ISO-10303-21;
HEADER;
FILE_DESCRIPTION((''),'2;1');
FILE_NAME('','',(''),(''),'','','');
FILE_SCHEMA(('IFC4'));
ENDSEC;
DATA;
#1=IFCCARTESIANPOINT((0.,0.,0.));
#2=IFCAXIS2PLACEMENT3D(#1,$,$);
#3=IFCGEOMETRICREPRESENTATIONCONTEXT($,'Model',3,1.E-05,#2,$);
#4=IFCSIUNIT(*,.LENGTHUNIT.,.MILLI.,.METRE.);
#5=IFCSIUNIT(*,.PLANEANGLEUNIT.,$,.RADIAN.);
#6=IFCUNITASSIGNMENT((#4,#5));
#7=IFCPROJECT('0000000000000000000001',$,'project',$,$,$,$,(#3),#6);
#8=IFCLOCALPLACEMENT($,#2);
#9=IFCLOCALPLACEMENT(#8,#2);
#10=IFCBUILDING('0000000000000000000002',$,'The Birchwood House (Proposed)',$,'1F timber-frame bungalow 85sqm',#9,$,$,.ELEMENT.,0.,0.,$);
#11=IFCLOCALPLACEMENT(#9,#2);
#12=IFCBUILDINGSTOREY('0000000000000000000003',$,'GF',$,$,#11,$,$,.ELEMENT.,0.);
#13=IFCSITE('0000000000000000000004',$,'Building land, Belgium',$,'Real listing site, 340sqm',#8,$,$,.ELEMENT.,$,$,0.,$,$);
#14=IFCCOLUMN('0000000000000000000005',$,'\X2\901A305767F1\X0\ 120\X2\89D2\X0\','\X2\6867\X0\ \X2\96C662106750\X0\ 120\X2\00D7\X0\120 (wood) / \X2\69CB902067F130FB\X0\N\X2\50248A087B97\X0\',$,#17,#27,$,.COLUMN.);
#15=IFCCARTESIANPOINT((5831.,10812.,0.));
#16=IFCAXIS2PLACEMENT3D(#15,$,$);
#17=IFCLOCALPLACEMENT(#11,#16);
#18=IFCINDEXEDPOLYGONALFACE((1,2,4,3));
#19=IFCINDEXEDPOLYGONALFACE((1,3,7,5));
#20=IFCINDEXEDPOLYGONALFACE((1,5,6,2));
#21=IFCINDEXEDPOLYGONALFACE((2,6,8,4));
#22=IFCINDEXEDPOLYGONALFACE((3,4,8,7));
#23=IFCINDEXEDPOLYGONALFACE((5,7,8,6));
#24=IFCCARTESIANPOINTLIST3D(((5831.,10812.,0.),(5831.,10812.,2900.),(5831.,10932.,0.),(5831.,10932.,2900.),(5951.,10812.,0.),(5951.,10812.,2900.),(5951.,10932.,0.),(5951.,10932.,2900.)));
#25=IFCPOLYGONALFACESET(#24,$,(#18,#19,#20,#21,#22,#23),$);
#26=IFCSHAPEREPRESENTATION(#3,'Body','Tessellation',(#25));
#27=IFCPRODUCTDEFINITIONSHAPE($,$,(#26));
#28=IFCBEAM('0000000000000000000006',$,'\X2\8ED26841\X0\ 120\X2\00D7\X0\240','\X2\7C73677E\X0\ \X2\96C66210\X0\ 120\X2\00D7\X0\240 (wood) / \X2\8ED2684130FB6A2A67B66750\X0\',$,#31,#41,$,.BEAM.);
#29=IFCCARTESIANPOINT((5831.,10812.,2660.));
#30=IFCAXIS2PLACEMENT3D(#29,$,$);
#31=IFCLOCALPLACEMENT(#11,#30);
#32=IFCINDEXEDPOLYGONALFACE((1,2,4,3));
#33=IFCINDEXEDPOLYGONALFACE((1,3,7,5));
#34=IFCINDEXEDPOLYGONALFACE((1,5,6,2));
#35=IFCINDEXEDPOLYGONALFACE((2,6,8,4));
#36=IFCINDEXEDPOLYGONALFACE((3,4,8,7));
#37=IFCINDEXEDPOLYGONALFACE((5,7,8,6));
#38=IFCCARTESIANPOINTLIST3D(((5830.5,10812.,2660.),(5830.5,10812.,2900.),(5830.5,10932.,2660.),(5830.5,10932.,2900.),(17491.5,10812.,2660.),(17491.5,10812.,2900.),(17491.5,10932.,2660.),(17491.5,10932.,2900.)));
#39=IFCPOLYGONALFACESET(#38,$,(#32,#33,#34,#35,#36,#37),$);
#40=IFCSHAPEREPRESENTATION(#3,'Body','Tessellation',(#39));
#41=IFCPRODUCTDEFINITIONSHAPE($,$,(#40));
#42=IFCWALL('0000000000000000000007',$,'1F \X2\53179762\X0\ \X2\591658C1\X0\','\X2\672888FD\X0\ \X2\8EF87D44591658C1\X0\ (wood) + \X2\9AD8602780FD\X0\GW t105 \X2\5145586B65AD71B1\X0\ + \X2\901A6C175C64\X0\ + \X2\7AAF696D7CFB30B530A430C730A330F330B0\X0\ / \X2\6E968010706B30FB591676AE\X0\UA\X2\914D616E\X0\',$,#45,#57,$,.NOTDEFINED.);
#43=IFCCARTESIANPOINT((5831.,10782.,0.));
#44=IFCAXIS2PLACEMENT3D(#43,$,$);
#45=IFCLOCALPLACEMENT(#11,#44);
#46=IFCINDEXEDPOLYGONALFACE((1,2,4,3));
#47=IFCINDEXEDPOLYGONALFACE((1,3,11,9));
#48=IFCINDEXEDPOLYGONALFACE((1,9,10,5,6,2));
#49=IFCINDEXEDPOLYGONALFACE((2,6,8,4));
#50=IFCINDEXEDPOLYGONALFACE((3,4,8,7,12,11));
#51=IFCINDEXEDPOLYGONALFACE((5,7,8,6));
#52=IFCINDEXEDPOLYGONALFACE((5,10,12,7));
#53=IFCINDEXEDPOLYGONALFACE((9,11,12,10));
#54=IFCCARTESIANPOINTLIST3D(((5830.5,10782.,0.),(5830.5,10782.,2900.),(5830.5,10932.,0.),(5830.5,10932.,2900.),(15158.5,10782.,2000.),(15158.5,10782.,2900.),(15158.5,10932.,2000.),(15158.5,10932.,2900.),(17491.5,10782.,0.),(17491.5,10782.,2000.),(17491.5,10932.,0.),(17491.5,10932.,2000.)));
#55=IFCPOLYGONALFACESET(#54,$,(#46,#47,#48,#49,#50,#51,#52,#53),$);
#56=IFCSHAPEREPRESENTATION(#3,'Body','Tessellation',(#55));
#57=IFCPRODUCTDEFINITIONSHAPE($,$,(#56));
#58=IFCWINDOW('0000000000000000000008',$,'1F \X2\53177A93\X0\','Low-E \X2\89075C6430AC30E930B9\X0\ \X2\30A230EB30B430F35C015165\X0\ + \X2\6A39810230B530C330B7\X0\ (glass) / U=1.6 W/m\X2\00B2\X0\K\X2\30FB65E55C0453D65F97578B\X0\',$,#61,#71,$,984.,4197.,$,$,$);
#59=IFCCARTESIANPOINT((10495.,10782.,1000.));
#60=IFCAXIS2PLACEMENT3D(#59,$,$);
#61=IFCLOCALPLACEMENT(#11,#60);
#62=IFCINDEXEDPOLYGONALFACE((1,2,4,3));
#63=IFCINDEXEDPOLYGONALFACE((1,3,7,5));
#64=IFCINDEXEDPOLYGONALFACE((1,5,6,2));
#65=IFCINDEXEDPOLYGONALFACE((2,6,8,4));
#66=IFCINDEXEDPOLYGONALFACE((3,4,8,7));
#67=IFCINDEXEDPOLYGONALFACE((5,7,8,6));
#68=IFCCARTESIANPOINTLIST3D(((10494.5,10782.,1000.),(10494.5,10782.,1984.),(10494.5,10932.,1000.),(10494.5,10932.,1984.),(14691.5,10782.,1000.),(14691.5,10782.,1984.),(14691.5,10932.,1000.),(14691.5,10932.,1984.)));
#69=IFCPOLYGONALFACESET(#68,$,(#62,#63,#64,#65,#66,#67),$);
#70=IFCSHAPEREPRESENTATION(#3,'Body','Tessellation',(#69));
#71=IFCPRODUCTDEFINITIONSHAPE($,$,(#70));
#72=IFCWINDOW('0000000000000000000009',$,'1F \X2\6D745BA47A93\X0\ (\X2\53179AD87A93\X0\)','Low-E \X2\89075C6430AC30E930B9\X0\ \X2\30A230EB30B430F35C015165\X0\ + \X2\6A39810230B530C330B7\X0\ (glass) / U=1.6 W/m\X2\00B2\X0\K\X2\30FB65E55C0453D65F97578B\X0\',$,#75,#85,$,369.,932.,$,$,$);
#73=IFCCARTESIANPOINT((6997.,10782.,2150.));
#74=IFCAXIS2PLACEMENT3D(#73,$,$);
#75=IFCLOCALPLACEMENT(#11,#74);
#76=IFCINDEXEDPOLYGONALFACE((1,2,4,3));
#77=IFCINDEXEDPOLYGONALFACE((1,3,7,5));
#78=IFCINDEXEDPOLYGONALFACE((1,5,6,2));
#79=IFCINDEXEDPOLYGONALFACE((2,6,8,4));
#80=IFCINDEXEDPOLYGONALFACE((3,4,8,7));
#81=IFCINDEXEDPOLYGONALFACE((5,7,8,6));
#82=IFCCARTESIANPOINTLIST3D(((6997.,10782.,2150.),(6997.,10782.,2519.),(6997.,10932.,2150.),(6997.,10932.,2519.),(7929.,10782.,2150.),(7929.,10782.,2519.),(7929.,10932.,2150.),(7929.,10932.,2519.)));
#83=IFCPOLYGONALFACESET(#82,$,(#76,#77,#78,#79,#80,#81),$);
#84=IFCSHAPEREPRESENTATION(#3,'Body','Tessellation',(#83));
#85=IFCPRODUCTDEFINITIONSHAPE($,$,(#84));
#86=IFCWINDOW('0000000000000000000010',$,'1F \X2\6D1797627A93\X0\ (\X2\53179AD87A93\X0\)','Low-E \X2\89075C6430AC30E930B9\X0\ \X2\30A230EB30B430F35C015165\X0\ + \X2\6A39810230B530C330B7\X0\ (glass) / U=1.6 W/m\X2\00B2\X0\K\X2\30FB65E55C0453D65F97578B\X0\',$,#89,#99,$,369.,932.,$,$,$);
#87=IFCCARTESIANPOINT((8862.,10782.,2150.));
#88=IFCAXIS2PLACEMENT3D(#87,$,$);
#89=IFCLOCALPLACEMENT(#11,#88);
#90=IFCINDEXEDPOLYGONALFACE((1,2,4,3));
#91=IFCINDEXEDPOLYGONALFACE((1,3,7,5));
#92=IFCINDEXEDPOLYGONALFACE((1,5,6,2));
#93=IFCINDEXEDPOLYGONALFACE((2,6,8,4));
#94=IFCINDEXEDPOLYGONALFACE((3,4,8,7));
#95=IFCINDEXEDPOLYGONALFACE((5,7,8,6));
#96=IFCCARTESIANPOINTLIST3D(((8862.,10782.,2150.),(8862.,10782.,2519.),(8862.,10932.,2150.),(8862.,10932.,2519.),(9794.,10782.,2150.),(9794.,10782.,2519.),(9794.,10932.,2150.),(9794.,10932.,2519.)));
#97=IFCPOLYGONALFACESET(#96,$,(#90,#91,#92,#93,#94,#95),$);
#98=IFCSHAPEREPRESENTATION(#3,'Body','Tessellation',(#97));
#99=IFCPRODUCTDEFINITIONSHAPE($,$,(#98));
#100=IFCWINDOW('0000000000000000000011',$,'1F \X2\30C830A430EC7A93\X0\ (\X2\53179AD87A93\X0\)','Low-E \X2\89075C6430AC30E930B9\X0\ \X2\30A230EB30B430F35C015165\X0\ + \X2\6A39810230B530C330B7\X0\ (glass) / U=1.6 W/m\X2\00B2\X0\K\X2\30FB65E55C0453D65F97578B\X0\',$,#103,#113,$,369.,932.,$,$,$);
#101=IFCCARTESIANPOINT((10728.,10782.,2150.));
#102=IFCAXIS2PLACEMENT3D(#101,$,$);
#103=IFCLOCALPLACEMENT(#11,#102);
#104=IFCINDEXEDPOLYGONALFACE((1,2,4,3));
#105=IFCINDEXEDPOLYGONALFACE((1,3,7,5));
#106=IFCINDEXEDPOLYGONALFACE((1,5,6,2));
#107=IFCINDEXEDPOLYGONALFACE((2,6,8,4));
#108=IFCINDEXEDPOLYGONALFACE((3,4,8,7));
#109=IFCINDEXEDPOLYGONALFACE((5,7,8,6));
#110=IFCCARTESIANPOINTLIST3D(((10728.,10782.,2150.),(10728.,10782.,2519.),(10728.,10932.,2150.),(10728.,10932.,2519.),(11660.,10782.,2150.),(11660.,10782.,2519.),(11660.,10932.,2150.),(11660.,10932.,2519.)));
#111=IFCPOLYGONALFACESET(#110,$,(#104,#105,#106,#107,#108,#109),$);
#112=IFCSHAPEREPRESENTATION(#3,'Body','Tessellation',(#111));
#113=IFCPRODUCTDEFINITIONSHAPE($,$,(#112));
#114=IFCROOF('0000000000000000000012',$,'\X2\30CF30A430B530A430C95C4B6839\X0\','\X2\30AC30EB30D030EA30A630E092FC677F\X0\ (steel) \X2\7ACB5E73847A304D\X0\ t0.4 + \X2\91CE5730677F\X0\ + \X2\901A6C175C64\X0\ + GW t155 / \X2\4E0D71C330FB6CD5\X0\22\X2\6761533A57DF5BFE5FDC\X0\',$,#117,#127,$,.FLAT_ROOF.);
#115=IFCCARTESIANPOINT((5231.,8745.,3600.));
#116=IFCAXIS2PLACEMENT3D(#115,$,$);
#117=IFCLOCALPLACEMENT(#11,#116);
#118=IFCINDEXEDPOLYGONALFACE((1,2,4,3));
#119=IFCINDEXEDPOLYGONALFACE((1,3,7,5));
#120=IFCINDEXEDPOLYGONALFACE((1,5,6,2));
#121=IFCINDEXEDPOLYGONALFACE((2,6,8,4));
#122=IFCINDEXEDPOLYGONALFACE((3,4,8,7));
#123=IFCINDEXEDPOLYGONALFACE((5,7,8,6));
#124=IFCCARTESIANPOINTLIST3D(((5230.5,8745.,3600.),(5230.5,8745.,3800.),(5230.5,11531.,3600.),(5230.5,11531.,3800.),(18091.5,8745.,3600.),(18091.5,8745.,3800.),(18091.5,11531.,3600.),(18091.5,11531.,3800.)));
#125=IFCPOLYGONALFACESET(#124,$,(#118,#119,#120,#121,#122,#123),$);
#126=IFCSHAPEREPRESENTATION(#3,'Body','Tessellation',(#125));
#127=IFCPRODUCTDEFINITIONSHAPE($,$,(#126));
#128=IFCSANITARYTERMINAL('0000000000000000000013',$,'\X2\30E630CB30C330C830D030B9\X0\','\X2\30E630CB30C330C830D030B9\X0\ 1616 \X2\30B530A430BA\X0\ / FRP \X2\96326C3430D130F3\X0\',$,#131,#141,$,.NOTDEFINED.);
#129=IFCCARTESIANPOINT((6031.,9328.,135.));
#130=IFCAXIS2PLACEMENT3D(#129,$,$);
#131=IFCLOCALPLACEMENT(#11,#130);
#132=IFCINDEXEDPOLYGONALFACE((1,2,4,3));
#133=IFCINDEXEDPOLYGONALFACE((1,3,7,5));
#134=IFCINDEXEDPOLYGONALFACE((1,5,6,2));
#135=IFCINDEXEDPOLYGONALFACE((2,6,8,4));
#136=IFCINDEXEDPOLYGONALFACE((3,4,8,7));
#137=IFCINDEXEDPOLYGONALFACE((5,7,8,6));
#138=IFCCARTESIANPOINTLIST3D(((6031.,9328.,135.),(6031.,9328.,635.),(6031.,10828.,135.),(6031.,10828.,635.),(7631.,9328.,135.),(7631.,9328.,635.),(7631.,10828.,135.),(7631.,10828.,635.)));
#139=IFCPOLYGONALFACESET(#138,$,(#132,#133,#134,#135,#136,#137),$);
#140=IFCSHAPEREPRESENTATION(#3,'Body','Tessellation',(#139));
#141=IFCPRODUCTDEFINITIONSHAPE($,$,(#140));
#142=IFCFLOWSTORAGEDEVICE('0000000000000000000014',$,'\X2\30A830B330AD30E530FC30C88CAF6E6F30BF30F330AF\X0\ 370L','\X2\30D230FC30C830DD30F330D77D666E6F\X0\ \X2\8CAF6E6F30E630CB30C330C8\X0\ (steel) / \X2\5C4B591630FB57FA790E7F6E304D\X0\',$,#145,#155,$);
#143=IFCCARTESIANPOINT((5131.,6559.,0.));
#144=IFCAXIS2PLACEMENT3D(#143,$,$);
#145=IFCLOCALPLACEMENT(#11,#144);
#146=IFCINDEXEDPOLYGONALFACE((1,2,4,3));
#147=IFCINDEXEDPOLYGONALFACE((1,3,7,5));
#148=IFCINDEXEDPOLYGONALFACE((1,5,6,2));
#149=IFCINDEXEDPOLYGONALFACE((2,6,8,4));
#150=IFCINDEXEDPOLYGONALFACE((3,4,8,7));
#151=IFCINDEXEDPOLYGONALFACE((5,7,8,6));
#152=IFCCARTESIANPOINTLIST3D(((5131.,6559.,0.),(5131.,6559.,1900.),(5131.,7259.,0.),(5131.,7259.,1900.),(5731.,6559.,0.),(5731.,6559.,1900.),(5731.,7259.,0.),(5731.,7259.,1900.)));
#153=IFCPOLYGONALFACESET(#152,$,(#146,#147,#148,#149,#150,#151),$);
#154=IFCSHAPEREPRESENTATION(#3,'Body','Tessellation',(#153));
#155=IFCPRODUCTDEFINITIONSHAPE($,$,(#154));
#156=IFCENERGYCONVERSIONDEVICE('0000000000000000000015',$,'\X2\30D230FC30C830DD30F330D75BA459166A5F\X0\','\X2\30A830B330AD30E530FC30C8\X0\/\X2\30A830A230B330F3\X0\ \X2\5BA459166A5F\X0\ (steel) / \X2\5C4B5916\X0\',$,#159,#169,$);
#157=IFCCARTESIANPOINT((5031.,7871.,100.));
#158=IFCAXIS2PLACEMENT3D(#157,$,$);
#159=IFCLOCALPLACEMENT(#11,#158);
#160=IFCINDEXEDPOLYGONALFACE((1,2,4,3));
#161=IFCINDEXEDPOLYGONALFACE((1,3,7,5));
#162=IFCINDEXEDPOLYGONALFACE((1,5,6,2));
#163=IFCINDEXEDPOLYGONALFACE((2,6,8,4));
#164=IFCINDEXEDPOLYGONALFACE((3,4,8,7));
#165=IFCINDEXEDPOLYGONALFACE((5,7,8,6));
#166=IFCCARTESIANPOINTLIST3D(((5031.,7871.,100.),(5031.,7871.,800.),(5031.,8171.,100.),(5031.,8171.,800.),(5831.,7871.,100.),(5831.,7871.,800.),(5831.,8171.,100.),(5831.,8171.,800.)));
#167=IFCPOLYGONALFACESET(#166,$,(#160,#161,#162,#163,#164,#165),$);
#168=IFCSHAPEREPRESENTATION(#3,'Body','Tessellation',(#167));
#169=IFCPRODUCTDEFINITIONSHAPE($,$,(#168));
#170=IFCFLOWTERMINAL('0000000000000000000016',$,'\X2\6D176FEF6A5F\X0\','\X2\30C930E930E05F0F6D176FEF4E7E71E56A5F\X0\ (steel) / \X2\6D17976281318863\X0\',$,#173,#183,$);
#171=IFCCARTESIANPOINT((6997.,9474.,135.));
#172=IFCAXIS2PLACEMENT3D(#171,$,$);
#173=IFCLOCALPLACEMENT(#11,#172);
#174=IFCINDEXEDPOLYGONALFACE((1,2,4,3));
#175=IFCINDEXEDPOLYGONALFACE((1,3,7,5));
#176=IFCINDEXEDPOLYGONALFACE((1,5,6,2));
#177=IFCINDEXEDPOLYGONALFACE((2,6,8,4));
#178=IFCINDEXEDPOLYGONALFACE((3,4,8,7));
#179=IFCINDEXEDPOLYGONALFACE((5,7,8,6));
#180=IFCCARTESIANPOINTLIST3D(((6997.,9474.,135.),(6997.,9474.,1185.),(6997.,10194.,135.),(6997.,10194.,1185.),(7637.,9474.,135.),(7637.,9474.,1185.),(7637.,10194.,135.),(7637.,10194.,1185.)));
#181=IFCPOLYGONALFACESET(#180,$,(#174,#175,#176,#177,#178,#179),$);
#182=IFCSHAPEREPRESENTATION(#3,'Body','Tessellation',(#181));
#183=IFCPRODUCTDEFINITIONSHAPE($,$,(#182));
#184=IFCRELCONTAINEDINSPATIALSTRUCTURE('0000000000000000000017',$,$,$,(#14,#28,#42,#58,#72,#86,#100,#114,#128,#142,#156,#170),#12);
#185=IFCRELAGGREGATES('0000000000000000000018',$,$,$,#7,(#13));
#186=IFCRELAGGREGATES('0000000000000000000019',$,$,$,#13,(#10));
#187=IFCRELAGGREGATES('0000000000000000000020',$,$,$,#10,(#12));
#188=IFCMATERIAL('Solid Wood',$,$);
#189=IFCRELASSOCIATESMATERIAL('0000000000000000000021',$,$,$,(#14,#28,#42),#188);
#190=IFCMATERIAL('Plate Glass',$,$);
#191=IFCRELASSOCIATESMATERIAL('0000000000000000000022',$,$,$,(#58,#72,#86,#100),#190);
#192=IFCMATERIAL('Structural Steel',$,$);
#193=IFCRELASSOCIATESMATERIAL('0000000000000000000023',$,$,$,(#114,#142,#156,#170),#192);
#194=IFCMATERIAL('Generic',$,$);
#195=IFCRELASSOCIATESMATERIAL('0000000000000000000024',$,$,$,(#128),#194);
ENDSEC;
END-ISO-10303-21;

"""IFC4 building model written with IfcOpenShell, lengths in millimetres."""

from ifc_helpers import new_model, si_unit, frame, frame_2d, origin, place, context, project, spatial, rectangle, extrude, material, element, fill, save


model = new_model("IFC4")

# Units and contexts
model_context = context("Model", 3, precision=1e-05, world=origin())
ifc_project = project(units=[si_unit("LENGTHUNIT", "METRE", prefix="MILLI"), si_unit("PLANEANGLEUNIT", "RADIAN")], contexts=[model_context])

# Site, building, storey
site_placement = place(None, origin())
site = spatial("IfcSite", under=ifc_project, at=site_placement, Name="Building land, Belgium", ObjectType="Real listing site, 340sqm", CompositionType="ELEMENT", RefElevation=0.0)
building_placement = place(site_placement, origin())
building = spatial("IfcBuilding", under=site, at=building_placement, Name="The Birchwood House (Proposed)", ObjectType="1F timber-frame bungalow 85sqm", CompositionType="ELEMENT", ElevationOfRefHeight=0.0, ElevationOfTerrain=0.0)
storey_placement = place(building_placement, origin())
storey = spatial("IfcBuildingStorey", under=building, at=storey_placement, Name="GF", CompositionType="ELEMENT", Elevation=0.0)

# Column
ifc_material_1 = material(Name="Solid Wood")
column_1_placement = place(storey_placement, frame((5831.0, 10812.0, 0.0)))
element("IfcColumn", 1, at=column_1_placement, inside=storey, material=ifc_material_1, Name="通し柱 120角", Description="桧 集成材 120×120 (wood) / 構造柱・N値計算", PredefinedType="COLUMN", context=model_context, shape_type="SweptSolid", body=[
    extrude(rectangle(XDim=120.0, YDim=120.0, at=frame_2d((60.0, 60.0))), frame((5831.0, 10812.0, 0.0)), (0.0, 0.0, 1.0), 2900.0),
])

# Beam
beam_1_placement = place(storey_placement, frame((5831.0, 10812.0, 2660.0)))
element("IfcBeam", 2, at=beam_1_placement, inside=storey, material=ifc_material_1, Name="軒桁 120×240", Description="米松 集成 120×240 (wood) / 軒桁・横架材", PredefinedType="BEAM", context=model_context, shape_type="SweptSolid", body=[
    extrude(rectangle(XDim=11661.0, YDim=120.0, at=frame_2d((5830.0, 60.0))), frame((5831.0, 10812.0, 2660.0)), (0.0, 0.0, 1.0), 240.0),
])

# Wall, openings, windows
wall_1_placement = place(storey_placement, frame((5831.0, 10782.0, 0.0)))
wall_1 = element("IfcWall", 3, at=wall_1_placement, inside=storey, material=ifc_material_1, Name="1F 北面 外壁", Description="木製 軸組外壁 (wood) + 高性能GW t105 充填断熱 + 通気層 + 窯業系サイディング / 準耐火・外皮UA配慮", PredefinedType="NOTDEFINED", context=model_context, shape_type="SweptSolid", body=[
    extrude(rectangle(XDim=11661.0, YDim=150.0, at=frame_2d((5830.0, 75.0))), frame((5831.0, 10782.0, 0.0)), (0.0, 0.0, 1.0), 2900.0),
])
opening_1_placement = place(storey_placement, frame((10495.0, 10782.0, 1000.0)))
opening_1 = element("IfcOpeningElement", 4, at=opening_1_placement, cuts=wall_1, PredefinedType="NOTDEFINED", context=model_context, shape_type="SweptSolid", body=[
    extrude(rectangle(XDim=4197.0, YDim=150.0, at=frame_2d((2098.0, 75.0))), frame((10495.0, 10782.0, 1000.0)), (0.0, 0.0, 1.0), 984.0),
])
opening_2_placement = place(storey_placement, frame((6997.0, 10782.0, 2150.0)))
opening_2 = element("IfcOpeningElement", 5, at=opening_2_placement, cuts=wall_1, PredefinedType="NOTDEFINED", context=model_context, shape_type="SweptSolid", body=[
    extrude(rectangle(XDim=932.0, YDim=150.0, at=frame_2d((466.0, 75.0))), frame((6997.0, 10782.0, 2150.0)), (0.0, 0.0, 1.0), 369.0),
])
opening_3_placement = place(storey_placement, frame((8862.0, 10782.0, 2150.0)))
opening_3 = element("IfcOpeningElement", 6, at=opening_3_placement, cuts=wall_1, PredefinedType="NOTDEFINED", context=model_context, shape_type="SweptSolid", body=[
    extrude(rectangle(XDim=932.0, YDim=150.0, at=frame_2d((466.0, 75.0))), frame((8862.0, 10782.0, 2150.0)), (0.0, 0.0, 1.0), 369.0),
])
opening_4_placement = place(storey_placement, frame((10728.0, 10782.0, 2150.0)))
opening_4 = element("IfcOpeningElement", 7, at=opening_4_placement, cuts=wall_1, PredefinedType="NOTDEFINED", context=model_context, shape_type="SweptSolid", body=[
    extrude(rectangle(XDim=932.0, YDim=150.0, at=frame_2d((466.0, 75.0))), frame((10728.0, 10782.0, 2150.0)), (0.0, 0.0, 1.0), 369.0),
])
ifc_material_2 = material(Name="Plate Glass")
window_1_placement = place(storey_placement, frame((10495.0, 10782.0, 1000.0)))
window_1 = element("IfcWindow", 8, at=window_1_placement, inside=storey, material=ifc_material_2, Name="1F 北窓", Description="Low-E 複層ガラス アルゴン封入 + 樹脂サッシ (glass) / U=1.6 W/m²K・日射取得型", OverallHeight=984.0, OverallWidth=4197.0, context=model_context, shape_type="SweptSolid", body=[
    extrude(rectangle(XDim=4197.0, YDim=150.0, at=frame_2d((2098.0, 75.0))), frame((10495.0, 10782.0, 1000.0)), (0.0, 0.0, 1.0), 984.0),
])
fill(opening_1, window_1)
window_2_placement = place(storey_placement, frame((6997.0, 10782.0, 2150.0)))
window_2 = element("IfcWindow", 9, at=window_2_placement, inside=storey, material=ifc_material_2, Name="1F 浴室窓 (北高窓)", Description="Low-E 複層ガラス アルゴン封入 + 樹脂サッシ (glass) / U=1.6 W/m²K・日射取得型", OverallHeight=369.0, OverallWidth=932.0, context=model_context, shape_type="SweptSolid", body=[
    extrude(rectangle(XDim=932.0, YDim=150.0, at=frame_2d((466.0, 75.0))), frame((6997.0, 10782.0, 2150.0)), (0.0, 0.0, 1.0), 369.0),
])
fill(opening_2, window_2)
window_3_placement = place(storey_placement, frame((8862.0, 10782.0, 2150.0)))
window_3 = element("IfcWindow", 10, at=window_3_placement, inside=storey, material=ifc_material_2, Name="1F 洗面窓 (北高窓)", Description="Low-E 複層ガラス アルゴン封入 + 樹脂サッシ (glass) / U=1.6 W/m²K・日射取得型", OverallHeight=369.0, OverallWidth=932.0, context=model_context, shape_type="SweptSolid", body=[
    extrude(rectangle(XDim=932.0, YDim=150.0, at=frame_2d((466.0, 75.0))), frame((8862.0, 10782.0, 2150.0)), (0.0, 0.0, 1.0), 369.0),
])
fill(opening_3, window_3)
window_4_placement = place(storey_placement, frame((10728.0, 10782.0, 2150.0)))
window_4 = element("IfcWindow", 11, at=window_4_placement, inside=storey, material=ifc_material_2, Name="1F トイレ窓 (北高窓)", Description="Low-E 複層ガラス アルゴン封入 + 樹脂サッシ (glass) / U=1.6 W/m²K・日射取得型", OverallHeight=369.0, OverallWidth=932.0, context=model_context, shape_type="SweptSolid", body=[
    extrude(rectangle(XDim=932.0, YDim=150.0, at=frame_2d((466.0, 75.0))), frame((10728.0, 10782.0, 2150.0)), (0.0, 0.0, 1.0), 369.0),
])
fill(opening_4, window_4)

# Roof
ifc_material_3 = material(Name="Structural Steel")
roof_placement = place(storey_placement, frame((5231.0, 8745.0, 3600.0)))
element("IfcRoof", 12, at=roof_placement, inside=storey, material=ifc_material_3, Name="ハイサイド屋根", Description="ガルバリウム鋼板 (steel) 立平葺き t0.4 + 野地板 + 通気層 + GW t155 / 不燃・法22条区域対応", PredefinedType="FLAT_ROOF", context=model_context, shape_type="SweptSolid", body=[
    extrude(rectangle(XDim=12861.0, YDim=2786.0, at=frame_2d((6430.0, 1393.0))), frame((5231.0, 8745.0, 3600.0)), (0.0, 0.0, 1.0), 200.0),
])

# Sanitary terminal
ifc_material_4 = material(Name="Generic")
sanitary_terminal_placement = place(storey_placement, frame((6031.0, 9328.0, 135.0)))
element("IfcSanitaryTerminal", 13, at=sanitary_terminal_placement, inside=storey, material=ifc_material_4, Name="ユニットバス", Description="ユニットバス 1616 サイズ / FRP 防水パン", PredefinedType="NOTDEFINED", context=model_context, shape_type="SweptSolid", body=[
    extrude(rectangle(XDim=1600.0, YDim=1500.0, at=frame_2d((800.0, 750.0))), frame((6031.0, 9328.0, 135.0)), (0.0, 0.0, 1.0), 500.0),
])

# Flow storage device
flow_storage_device_placement = place(storey_placement, frame((5131.0, 6559.0, 0.0)))
element("IfcFlowStorageDevice", 14, at=flow_storage_device_placement, inside=storey, material=ifc_material_3, Name="エコキュート貯湯タンク 370L", Description="ヒートポンプ給湯 貯湯ユニット (steel) / 屋外・基礎置き", context=model_context, shape_type="SweptSolid", body=[
    extrude(rectangle(XDim=600.0, YDim=700.0, at=frame_2d((300.0, 350.0))), frame((5131.0, 6559.0, 0.0)), (0.0, 0.0, 1.0), 1900.0),
])

# Energy conversion device
energy_conversion_device_placement = place(storey_placement, frame((5031.0, 7871.0, 100.0)))
element("IfcEnergyConversionDevice", 15, at=energy_conversion_device_placement, inside=storey, material=ifc_material_3, Name="ヒートポンプ室外機", Description="エコキュート/エアコン 室外機 (steel) / 屋外", context=model_context, shape_type="SweptSolid", body=[
    extrude(rectangle(XDim=800.0, YDim=300.0, at=frame_2d((400.0, 150.0))), frame((5031.0, 7871.0, 100.0)), (0.0, 0.0, 1.0), 700.0),
])

# Flow terminal
flow_terminal_placement = place(storey_placement, frame((6997.0, 9474.0, 135.0)))
element("IfcFlowTerminal", 16, at=flow_terminal_placement, inside=storey, material=ifc_material_3, Name="洗濯機", Description="ドラム式洗濯乾燥機 (steel) / 洗面脱衣", context=model_context, shape_type="SweptSolid", body=[
    extrude(rectangle(XDim=640.0, YDim=720.0, at=frame_2d((320.0, 360.0))), frame((6997.0, 9474.0, 135.0)), (0.0, 0.0, 1.0), 1050.0),
])

save(model, "model.ifc")
